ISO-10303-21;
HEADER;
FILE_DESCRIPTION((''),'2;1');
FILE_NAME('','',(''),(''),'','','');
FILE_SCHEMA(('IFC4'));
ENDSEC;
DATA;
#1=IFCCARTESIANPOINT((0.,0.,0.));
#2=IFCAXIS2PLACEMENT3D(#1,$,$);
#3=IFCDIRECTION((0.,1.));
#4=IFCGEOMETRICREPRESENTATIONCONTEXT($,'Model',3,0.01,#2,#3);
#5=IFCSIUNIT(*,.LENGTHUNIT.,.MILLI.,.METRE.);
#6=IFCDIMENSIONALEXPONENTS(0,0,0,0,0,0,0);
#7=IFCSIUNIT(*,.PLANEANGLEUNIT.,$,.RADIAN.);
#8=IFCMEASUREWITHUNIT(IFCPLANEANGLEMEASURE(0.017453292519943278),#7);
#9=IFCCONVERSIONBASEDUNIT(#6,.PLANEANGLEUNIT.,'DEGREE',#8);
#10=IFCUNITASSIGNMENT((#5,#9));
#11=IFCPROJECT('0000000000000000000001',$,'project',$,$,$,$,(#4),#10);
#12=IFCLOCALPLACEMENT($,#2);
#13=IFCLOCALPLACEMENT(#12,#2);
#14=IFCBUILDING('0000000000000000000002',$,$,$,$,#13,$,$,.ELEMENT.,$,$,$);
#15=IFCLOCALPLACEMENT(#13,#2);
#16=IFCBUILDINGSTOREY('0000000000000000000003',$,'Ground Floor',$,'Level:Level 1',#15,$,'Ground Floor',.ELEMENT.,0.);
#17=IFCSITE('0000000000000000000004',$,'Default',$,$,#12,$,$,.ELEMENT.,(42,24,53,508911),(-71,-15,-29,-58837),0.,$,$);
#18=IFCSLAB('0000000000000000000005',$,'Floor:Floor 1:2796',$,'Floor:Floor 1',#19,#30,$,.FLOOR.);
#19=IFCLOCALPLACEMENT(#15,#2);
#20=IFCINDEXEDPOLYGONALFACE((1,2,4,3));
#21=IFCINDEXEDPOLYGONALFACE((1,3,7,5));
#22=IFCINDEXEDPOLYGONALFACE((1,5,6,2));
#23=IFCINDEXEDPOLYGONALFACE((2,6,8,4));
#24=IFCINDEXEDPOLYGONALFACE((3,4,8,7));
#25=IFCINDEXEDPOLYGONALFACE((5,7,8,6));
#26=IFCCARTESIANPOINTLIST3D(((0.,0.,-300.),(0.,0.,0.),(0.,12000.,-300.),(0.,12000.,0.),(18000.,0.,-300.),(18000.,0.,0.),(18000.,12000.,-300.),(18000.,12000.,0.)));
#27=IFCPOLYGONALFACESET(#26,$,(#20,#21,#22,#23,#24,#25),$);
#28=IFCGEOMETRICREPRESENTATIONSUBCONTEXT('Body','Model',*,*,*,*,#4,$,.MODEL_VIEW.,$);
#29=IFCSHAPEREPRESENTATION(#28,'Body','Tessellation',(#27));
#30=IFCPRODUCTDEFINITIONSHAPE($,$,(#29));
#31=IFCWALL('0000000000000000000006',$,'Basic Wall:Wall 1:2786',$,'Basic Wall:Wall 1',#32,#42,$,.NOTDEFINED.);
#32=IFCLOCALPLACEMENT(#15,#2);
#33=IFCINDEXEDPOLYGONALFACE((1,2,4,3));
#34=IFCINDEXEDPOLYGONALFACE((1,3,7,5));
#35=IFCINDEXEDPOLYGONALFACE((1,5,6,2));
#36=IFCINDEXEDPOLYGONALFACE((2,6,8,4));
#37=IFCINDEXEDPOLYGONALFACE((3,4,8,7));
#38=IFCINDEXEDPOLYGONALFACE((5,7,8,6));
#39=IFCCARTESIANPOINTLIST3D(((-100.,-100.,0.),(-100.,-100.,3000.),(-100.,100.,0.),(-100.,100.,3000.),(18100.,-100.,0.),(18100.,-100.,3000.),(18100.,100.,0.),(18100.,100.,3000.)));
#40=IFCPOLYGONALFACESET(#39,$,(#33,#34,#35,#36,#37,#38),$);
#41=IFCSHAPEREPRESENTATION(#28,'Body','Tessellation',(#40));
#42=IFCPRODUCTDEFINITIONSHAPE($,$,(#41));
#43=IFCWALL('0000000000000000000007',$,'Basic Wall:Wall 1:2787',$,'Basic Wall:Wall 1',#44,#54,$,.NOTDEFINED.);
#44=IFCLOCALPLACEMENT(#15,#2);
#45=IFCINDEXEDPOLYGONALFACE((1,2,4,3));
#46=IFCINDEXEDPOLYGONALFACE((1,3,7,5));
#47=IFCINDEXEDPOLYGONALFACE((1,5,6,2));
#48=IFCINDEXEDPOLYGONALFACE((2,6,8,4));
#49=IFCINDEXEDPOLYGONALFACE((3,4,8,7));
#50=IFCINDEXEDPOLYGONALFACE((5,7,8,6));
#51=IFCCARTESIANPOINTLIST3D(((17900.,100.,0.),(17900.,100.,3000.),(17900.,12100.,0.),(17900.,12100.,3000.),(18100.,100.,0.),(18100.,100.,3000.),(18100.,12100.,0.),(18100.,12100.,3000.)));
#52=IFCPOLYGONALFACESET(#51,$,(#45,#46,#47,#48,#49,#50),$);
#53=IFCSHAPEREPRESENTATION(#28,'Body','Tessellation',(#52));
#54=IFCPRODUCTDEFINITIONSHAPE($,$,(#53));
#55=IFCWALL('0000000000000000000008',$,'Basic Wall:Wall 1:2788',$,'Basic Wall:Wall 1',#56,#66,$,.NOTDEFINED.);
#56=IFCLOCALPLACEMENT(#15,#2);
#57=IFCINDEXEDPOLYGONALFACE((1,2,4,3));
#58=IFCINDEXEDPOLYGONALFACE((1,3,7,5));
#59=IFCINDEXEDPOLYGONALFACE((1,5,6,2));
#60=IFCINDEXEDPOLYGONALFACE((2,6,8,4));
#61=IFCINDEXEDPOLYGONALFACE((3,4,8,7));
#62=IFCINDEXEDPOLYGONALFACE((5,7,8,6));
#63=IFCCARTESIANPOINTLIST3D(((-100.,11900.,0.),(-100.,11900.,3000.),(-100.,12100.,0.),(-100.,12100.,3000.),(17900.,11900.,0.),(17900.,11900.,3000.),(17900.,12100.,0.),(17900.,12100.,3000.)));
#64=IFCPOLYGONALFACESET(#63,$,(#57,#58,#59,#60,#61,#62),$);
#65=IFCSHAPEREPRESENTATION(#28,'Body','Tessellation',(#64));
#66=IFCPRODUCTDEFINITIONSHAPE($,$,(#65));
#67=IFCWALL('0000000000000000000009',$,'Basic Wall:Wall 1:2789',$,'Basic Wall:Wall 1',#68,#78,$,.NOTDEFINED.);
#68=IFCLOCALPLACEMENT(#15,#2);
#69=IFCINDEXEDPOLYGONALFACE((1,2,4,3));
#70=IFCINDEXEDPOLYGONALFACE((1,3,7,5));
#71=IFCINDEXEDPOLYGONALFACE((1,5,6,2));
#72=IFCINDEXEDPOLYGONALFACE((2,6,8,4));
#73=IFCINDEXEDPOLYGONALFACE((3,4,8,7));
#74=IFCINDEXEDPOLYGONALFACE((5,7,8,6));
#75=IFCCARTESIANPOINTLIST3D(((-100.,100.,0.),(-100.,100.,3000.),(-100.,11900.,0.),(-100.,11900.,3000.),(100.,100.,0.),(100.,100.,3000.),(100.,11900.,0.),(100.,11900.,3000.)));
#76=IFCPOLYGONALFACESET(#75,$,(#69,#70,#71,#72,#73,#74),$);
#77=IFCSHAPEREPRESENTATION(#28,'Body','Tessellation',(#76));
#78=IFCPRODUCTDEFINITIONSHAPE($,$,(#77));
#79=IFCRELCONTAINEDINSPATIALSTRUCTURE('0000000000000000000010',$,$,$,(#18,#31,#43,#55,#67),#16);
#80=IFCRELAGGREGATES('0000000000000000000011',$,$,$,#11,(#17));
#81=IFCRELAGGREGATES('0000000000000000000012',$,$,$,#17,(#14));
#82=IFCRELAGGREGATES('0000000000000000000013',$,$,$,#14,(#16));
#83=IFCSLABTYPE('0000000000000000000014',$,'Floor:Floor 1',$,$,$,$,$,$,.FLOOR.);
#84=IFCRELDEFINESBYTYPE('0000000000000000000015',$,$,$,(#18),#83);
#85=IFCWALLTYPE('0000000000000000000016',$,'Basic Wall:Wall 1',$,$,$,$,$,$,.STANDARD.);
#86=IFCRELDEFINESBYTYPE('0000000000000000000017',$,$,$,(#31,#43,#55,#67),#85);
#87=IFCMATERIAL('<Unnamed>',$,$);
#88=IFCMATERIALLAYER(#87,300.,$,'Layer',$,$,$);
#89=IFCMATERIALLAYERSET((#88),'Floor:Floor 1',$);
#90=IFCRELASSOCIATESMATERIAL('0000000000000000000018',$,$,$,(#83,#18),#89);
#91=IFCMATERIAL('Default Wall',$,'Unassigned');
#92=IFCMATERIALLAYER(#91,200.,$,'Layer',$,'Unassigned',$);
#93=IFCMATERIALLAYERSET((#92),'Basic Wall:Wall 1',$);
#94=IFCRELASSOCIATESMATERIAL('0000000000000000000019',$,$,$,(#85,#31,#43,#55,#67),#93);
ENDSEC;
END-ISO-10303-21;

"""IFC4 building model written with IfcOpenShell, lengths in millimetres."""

from ifc_helpers import new_model, entity, si_unit, converted_unit, direction, frame, frame_2d, origin, origin_2d_with_axis, place, context, subcontext, project, spatial, rectangle, extrude, material, layer, layer_set, layer_usage, type_object, element, save


model = new_model("IFC4")

# Units and contexts
model_context = context("Model", 3, precision=0.01, world=origin(), true_north=direction((0.0, 1.0)))
body_context = subcontext(model_context, "Body", "Model", "MODEL_VIEW")
ifc_project = project(units=[si_unit("LENGTHUNIT", "METRE", prefix="MILLI"), converted_unit("PLANEANGLEUNIT", "DEGREE", entity("IfcPlaneAngleMeasure", 0.017453292519943278), si_unit("PLANEANGLEUNIT", "RADIAN"), dimensions=[0, 0, 0, 0, 0, 0, 0])], contexts=[model_context])

# Site, building, storey
site_placement = place(None, origin())
site = spatial("IfcSite", under=ifc_project, at=site_placement, Name="Default", CompositionType="ELEMENT", RefLatitude=(42, 24, 53, 508911), RefLongitude=(-71, -15, -29, -58837), RefElevation=0.0)
building_placement = place(site_placement, origin())
building = spatial("IfcBuilding", under=site, at=building_placement, CompositionType="ELEMENT")
storey_placement = place(building_placement, origin())
storey = spatial("IfcBuildingStorey", under=building, at=storey_placement, Name="Ground Floor", ObjectType="Level:Level 1", LongName="Ground Floor", CompositionType="ELEMENT", Elevation=0.0)

# Shared definitions
ifc_material_1 = material(Name="Default Wall", Category="Unassigned")

# Slab
ifc_material_2 = material(Name="<Unnamed>")
ifc_layer_1 = layer(ifc_material_2, 300.0, Name="Layer")
ifc_layer_set_1 = layer_set([ifc_layer_1], Name="Floor:Floor 1")
ifc_layer_usage_1 = layer_usage(ifc_layer_set_1, "AXIS3", "POSITIVE", 0.0)
slab_type = type_object("IfcSlabType", Name="Floor:Floor 1", PredefinedType="FLOOR", material=ifc_layer_set_1)
slab_placement = place(storey_placement, origin())
element("IfcSlab", 1, at=slab_placement, inside=storey, type_object=slab_type, material=ifc_layer_usage_1, Name="Floor:Floor 1:2796", ObjectType="Floor:Floor 1", PredefinedType="FLOOR", context=body_context, shape_type="SweptSolid", body=[
    extrude(rectangle(XDim=12000.0, YDim=18000.0, at=origin_2d_with_axis()), frame((9000.0, 6000.0, 0.0), z_axis=(0.0, 0.0, -1.0), x_axis=(0.0, 1.0, 0.0)), (0.0, 0.0, 1.0), 300.0),
])

# Walls
ifc_layer_2 = layer(ifc_material_1, 200.0, Name="Layer", Category="Unassigned")
ifc_layer_set_2 = layer_set([ifc_layer_2], Name="Basic Wall:Wall 1")
ifc_layer_usage_2 = layer_usage(ifc_layer_set_2, "AXIS2", "NEGATIVE", 100.0)
wall_type = type_object("IfcWallType", Name="Basic Wall:Wall 1", PredefinedType="STANDARD", material=ifc_layer_set_2)
wall_1_placement = place(storey_placement, frame((-100.0, 0.0, 0.0)))
element("IfcWall", 2, at=wall_1_placement, inside=storey, type_object=wall_type, material=ifc_layer_usage_2, Name="Basic Wall:Wall 1:2786", ObjectType="Basic Wall:Wall 1", PredefinedType="NOTDEFINED", context=body_context, shape_type="SweptSolid", body=[
    extrude(rectangle(XDim=18200.0, YDim=200.0, at=frame_2d((9100.0, 0.0), x_axis=(-1.0, 0.0))), origin(), (0.0, 0.0, 1.0), 3000.0),
])
ifc_layer_usage_3 = layer_usage(ifc_layer_set_2, "AXIS2", "NEGATIVE", 100.0)
wall_2_placement = place(storey_placement, frame((18000.0, 100.0, 0.0), z_axis=(0.0, 0.0, 1.0), x_axis=(0.0, 1.0, 0.0)))
element("IfcWall", 3, at=wall_2_placement, inside=storey, type_object=wall_type, material=ifc_layer_usage_3, Name="Basic Wall:Wall 1:2787", ObjectType="Basic Wall:Wall 1", PredefinedType="NOTDEFINED", context=body_context, shape_type="SweptSolid", body=[
    extrude(rectangle(XDim=12000.0, YDim=200.0, at=frame_2d((6000.0, 0.0), x_axis=(-1.0, 0.0))), origin(), (0.0, 0.0, 1.0), 3000.0),
])
ifc_layer_usage_4 = layer_usage(ifc_layer_set_2, "AXIS2", "NEGATIVE", 100.0)
wall_3_placement = place(storey_placement, frame((17900.0, 12000.0, 0.0), z_axis=(0.0, 0.0, 1.0), x_axis=(-1.0, 0.0, 0.0)))
element("IfcWall", 4, at=wall_3_placement, inside=storey, type_object=wall_type, material=ifc_layer_usage_4, Name="Basic Wall:Wall 1:2788", ObjectType="Basic Wall:Wall 1", PredefinedType="NOTDEFINED", context=body_context, shape_type="SweptSolid", body=[
    extrude(rectangle(XDim=18000.0, YDim=200.0, at=frame_2d((9000.0, 0.0), x_axis=(-1.0, 0.0))), origin(), (0.0, 0.0, 1.0), 3000.0),
])
ifc_layer_usage_5 = layer_usage(ifc_layer_set_2, "AXIS2", "NEGATIVE", 100.0)
wall_4_placement = place(storey_placement, frame((0.0, 11900.0, 0.0), z_axis=(0.0, 0.0, 1.0), x_axis=(0.0, -1.0, 0.0)))
element("IfcWall", 5, at=wall_4_placement, inside=storey, type_object=wall_type, material=ifc_layer_usage_5, Name="Basic Wall:Wall 1:2789", ObjectType="Basic Wall:Wall 1", PredefinedType="NOTDEFINED", context=body_context, shape_type="SweptSolid", body=[
    extrude(rectangle(XDim=11800.0, YDim=200.0, at=frame_2d((5900.0, 0.0), x_axis=(-1.0, 0.0))), origin(), (0.0, 0.0, 1.0), 3000.0),
])

save(model, "model.ifc")
